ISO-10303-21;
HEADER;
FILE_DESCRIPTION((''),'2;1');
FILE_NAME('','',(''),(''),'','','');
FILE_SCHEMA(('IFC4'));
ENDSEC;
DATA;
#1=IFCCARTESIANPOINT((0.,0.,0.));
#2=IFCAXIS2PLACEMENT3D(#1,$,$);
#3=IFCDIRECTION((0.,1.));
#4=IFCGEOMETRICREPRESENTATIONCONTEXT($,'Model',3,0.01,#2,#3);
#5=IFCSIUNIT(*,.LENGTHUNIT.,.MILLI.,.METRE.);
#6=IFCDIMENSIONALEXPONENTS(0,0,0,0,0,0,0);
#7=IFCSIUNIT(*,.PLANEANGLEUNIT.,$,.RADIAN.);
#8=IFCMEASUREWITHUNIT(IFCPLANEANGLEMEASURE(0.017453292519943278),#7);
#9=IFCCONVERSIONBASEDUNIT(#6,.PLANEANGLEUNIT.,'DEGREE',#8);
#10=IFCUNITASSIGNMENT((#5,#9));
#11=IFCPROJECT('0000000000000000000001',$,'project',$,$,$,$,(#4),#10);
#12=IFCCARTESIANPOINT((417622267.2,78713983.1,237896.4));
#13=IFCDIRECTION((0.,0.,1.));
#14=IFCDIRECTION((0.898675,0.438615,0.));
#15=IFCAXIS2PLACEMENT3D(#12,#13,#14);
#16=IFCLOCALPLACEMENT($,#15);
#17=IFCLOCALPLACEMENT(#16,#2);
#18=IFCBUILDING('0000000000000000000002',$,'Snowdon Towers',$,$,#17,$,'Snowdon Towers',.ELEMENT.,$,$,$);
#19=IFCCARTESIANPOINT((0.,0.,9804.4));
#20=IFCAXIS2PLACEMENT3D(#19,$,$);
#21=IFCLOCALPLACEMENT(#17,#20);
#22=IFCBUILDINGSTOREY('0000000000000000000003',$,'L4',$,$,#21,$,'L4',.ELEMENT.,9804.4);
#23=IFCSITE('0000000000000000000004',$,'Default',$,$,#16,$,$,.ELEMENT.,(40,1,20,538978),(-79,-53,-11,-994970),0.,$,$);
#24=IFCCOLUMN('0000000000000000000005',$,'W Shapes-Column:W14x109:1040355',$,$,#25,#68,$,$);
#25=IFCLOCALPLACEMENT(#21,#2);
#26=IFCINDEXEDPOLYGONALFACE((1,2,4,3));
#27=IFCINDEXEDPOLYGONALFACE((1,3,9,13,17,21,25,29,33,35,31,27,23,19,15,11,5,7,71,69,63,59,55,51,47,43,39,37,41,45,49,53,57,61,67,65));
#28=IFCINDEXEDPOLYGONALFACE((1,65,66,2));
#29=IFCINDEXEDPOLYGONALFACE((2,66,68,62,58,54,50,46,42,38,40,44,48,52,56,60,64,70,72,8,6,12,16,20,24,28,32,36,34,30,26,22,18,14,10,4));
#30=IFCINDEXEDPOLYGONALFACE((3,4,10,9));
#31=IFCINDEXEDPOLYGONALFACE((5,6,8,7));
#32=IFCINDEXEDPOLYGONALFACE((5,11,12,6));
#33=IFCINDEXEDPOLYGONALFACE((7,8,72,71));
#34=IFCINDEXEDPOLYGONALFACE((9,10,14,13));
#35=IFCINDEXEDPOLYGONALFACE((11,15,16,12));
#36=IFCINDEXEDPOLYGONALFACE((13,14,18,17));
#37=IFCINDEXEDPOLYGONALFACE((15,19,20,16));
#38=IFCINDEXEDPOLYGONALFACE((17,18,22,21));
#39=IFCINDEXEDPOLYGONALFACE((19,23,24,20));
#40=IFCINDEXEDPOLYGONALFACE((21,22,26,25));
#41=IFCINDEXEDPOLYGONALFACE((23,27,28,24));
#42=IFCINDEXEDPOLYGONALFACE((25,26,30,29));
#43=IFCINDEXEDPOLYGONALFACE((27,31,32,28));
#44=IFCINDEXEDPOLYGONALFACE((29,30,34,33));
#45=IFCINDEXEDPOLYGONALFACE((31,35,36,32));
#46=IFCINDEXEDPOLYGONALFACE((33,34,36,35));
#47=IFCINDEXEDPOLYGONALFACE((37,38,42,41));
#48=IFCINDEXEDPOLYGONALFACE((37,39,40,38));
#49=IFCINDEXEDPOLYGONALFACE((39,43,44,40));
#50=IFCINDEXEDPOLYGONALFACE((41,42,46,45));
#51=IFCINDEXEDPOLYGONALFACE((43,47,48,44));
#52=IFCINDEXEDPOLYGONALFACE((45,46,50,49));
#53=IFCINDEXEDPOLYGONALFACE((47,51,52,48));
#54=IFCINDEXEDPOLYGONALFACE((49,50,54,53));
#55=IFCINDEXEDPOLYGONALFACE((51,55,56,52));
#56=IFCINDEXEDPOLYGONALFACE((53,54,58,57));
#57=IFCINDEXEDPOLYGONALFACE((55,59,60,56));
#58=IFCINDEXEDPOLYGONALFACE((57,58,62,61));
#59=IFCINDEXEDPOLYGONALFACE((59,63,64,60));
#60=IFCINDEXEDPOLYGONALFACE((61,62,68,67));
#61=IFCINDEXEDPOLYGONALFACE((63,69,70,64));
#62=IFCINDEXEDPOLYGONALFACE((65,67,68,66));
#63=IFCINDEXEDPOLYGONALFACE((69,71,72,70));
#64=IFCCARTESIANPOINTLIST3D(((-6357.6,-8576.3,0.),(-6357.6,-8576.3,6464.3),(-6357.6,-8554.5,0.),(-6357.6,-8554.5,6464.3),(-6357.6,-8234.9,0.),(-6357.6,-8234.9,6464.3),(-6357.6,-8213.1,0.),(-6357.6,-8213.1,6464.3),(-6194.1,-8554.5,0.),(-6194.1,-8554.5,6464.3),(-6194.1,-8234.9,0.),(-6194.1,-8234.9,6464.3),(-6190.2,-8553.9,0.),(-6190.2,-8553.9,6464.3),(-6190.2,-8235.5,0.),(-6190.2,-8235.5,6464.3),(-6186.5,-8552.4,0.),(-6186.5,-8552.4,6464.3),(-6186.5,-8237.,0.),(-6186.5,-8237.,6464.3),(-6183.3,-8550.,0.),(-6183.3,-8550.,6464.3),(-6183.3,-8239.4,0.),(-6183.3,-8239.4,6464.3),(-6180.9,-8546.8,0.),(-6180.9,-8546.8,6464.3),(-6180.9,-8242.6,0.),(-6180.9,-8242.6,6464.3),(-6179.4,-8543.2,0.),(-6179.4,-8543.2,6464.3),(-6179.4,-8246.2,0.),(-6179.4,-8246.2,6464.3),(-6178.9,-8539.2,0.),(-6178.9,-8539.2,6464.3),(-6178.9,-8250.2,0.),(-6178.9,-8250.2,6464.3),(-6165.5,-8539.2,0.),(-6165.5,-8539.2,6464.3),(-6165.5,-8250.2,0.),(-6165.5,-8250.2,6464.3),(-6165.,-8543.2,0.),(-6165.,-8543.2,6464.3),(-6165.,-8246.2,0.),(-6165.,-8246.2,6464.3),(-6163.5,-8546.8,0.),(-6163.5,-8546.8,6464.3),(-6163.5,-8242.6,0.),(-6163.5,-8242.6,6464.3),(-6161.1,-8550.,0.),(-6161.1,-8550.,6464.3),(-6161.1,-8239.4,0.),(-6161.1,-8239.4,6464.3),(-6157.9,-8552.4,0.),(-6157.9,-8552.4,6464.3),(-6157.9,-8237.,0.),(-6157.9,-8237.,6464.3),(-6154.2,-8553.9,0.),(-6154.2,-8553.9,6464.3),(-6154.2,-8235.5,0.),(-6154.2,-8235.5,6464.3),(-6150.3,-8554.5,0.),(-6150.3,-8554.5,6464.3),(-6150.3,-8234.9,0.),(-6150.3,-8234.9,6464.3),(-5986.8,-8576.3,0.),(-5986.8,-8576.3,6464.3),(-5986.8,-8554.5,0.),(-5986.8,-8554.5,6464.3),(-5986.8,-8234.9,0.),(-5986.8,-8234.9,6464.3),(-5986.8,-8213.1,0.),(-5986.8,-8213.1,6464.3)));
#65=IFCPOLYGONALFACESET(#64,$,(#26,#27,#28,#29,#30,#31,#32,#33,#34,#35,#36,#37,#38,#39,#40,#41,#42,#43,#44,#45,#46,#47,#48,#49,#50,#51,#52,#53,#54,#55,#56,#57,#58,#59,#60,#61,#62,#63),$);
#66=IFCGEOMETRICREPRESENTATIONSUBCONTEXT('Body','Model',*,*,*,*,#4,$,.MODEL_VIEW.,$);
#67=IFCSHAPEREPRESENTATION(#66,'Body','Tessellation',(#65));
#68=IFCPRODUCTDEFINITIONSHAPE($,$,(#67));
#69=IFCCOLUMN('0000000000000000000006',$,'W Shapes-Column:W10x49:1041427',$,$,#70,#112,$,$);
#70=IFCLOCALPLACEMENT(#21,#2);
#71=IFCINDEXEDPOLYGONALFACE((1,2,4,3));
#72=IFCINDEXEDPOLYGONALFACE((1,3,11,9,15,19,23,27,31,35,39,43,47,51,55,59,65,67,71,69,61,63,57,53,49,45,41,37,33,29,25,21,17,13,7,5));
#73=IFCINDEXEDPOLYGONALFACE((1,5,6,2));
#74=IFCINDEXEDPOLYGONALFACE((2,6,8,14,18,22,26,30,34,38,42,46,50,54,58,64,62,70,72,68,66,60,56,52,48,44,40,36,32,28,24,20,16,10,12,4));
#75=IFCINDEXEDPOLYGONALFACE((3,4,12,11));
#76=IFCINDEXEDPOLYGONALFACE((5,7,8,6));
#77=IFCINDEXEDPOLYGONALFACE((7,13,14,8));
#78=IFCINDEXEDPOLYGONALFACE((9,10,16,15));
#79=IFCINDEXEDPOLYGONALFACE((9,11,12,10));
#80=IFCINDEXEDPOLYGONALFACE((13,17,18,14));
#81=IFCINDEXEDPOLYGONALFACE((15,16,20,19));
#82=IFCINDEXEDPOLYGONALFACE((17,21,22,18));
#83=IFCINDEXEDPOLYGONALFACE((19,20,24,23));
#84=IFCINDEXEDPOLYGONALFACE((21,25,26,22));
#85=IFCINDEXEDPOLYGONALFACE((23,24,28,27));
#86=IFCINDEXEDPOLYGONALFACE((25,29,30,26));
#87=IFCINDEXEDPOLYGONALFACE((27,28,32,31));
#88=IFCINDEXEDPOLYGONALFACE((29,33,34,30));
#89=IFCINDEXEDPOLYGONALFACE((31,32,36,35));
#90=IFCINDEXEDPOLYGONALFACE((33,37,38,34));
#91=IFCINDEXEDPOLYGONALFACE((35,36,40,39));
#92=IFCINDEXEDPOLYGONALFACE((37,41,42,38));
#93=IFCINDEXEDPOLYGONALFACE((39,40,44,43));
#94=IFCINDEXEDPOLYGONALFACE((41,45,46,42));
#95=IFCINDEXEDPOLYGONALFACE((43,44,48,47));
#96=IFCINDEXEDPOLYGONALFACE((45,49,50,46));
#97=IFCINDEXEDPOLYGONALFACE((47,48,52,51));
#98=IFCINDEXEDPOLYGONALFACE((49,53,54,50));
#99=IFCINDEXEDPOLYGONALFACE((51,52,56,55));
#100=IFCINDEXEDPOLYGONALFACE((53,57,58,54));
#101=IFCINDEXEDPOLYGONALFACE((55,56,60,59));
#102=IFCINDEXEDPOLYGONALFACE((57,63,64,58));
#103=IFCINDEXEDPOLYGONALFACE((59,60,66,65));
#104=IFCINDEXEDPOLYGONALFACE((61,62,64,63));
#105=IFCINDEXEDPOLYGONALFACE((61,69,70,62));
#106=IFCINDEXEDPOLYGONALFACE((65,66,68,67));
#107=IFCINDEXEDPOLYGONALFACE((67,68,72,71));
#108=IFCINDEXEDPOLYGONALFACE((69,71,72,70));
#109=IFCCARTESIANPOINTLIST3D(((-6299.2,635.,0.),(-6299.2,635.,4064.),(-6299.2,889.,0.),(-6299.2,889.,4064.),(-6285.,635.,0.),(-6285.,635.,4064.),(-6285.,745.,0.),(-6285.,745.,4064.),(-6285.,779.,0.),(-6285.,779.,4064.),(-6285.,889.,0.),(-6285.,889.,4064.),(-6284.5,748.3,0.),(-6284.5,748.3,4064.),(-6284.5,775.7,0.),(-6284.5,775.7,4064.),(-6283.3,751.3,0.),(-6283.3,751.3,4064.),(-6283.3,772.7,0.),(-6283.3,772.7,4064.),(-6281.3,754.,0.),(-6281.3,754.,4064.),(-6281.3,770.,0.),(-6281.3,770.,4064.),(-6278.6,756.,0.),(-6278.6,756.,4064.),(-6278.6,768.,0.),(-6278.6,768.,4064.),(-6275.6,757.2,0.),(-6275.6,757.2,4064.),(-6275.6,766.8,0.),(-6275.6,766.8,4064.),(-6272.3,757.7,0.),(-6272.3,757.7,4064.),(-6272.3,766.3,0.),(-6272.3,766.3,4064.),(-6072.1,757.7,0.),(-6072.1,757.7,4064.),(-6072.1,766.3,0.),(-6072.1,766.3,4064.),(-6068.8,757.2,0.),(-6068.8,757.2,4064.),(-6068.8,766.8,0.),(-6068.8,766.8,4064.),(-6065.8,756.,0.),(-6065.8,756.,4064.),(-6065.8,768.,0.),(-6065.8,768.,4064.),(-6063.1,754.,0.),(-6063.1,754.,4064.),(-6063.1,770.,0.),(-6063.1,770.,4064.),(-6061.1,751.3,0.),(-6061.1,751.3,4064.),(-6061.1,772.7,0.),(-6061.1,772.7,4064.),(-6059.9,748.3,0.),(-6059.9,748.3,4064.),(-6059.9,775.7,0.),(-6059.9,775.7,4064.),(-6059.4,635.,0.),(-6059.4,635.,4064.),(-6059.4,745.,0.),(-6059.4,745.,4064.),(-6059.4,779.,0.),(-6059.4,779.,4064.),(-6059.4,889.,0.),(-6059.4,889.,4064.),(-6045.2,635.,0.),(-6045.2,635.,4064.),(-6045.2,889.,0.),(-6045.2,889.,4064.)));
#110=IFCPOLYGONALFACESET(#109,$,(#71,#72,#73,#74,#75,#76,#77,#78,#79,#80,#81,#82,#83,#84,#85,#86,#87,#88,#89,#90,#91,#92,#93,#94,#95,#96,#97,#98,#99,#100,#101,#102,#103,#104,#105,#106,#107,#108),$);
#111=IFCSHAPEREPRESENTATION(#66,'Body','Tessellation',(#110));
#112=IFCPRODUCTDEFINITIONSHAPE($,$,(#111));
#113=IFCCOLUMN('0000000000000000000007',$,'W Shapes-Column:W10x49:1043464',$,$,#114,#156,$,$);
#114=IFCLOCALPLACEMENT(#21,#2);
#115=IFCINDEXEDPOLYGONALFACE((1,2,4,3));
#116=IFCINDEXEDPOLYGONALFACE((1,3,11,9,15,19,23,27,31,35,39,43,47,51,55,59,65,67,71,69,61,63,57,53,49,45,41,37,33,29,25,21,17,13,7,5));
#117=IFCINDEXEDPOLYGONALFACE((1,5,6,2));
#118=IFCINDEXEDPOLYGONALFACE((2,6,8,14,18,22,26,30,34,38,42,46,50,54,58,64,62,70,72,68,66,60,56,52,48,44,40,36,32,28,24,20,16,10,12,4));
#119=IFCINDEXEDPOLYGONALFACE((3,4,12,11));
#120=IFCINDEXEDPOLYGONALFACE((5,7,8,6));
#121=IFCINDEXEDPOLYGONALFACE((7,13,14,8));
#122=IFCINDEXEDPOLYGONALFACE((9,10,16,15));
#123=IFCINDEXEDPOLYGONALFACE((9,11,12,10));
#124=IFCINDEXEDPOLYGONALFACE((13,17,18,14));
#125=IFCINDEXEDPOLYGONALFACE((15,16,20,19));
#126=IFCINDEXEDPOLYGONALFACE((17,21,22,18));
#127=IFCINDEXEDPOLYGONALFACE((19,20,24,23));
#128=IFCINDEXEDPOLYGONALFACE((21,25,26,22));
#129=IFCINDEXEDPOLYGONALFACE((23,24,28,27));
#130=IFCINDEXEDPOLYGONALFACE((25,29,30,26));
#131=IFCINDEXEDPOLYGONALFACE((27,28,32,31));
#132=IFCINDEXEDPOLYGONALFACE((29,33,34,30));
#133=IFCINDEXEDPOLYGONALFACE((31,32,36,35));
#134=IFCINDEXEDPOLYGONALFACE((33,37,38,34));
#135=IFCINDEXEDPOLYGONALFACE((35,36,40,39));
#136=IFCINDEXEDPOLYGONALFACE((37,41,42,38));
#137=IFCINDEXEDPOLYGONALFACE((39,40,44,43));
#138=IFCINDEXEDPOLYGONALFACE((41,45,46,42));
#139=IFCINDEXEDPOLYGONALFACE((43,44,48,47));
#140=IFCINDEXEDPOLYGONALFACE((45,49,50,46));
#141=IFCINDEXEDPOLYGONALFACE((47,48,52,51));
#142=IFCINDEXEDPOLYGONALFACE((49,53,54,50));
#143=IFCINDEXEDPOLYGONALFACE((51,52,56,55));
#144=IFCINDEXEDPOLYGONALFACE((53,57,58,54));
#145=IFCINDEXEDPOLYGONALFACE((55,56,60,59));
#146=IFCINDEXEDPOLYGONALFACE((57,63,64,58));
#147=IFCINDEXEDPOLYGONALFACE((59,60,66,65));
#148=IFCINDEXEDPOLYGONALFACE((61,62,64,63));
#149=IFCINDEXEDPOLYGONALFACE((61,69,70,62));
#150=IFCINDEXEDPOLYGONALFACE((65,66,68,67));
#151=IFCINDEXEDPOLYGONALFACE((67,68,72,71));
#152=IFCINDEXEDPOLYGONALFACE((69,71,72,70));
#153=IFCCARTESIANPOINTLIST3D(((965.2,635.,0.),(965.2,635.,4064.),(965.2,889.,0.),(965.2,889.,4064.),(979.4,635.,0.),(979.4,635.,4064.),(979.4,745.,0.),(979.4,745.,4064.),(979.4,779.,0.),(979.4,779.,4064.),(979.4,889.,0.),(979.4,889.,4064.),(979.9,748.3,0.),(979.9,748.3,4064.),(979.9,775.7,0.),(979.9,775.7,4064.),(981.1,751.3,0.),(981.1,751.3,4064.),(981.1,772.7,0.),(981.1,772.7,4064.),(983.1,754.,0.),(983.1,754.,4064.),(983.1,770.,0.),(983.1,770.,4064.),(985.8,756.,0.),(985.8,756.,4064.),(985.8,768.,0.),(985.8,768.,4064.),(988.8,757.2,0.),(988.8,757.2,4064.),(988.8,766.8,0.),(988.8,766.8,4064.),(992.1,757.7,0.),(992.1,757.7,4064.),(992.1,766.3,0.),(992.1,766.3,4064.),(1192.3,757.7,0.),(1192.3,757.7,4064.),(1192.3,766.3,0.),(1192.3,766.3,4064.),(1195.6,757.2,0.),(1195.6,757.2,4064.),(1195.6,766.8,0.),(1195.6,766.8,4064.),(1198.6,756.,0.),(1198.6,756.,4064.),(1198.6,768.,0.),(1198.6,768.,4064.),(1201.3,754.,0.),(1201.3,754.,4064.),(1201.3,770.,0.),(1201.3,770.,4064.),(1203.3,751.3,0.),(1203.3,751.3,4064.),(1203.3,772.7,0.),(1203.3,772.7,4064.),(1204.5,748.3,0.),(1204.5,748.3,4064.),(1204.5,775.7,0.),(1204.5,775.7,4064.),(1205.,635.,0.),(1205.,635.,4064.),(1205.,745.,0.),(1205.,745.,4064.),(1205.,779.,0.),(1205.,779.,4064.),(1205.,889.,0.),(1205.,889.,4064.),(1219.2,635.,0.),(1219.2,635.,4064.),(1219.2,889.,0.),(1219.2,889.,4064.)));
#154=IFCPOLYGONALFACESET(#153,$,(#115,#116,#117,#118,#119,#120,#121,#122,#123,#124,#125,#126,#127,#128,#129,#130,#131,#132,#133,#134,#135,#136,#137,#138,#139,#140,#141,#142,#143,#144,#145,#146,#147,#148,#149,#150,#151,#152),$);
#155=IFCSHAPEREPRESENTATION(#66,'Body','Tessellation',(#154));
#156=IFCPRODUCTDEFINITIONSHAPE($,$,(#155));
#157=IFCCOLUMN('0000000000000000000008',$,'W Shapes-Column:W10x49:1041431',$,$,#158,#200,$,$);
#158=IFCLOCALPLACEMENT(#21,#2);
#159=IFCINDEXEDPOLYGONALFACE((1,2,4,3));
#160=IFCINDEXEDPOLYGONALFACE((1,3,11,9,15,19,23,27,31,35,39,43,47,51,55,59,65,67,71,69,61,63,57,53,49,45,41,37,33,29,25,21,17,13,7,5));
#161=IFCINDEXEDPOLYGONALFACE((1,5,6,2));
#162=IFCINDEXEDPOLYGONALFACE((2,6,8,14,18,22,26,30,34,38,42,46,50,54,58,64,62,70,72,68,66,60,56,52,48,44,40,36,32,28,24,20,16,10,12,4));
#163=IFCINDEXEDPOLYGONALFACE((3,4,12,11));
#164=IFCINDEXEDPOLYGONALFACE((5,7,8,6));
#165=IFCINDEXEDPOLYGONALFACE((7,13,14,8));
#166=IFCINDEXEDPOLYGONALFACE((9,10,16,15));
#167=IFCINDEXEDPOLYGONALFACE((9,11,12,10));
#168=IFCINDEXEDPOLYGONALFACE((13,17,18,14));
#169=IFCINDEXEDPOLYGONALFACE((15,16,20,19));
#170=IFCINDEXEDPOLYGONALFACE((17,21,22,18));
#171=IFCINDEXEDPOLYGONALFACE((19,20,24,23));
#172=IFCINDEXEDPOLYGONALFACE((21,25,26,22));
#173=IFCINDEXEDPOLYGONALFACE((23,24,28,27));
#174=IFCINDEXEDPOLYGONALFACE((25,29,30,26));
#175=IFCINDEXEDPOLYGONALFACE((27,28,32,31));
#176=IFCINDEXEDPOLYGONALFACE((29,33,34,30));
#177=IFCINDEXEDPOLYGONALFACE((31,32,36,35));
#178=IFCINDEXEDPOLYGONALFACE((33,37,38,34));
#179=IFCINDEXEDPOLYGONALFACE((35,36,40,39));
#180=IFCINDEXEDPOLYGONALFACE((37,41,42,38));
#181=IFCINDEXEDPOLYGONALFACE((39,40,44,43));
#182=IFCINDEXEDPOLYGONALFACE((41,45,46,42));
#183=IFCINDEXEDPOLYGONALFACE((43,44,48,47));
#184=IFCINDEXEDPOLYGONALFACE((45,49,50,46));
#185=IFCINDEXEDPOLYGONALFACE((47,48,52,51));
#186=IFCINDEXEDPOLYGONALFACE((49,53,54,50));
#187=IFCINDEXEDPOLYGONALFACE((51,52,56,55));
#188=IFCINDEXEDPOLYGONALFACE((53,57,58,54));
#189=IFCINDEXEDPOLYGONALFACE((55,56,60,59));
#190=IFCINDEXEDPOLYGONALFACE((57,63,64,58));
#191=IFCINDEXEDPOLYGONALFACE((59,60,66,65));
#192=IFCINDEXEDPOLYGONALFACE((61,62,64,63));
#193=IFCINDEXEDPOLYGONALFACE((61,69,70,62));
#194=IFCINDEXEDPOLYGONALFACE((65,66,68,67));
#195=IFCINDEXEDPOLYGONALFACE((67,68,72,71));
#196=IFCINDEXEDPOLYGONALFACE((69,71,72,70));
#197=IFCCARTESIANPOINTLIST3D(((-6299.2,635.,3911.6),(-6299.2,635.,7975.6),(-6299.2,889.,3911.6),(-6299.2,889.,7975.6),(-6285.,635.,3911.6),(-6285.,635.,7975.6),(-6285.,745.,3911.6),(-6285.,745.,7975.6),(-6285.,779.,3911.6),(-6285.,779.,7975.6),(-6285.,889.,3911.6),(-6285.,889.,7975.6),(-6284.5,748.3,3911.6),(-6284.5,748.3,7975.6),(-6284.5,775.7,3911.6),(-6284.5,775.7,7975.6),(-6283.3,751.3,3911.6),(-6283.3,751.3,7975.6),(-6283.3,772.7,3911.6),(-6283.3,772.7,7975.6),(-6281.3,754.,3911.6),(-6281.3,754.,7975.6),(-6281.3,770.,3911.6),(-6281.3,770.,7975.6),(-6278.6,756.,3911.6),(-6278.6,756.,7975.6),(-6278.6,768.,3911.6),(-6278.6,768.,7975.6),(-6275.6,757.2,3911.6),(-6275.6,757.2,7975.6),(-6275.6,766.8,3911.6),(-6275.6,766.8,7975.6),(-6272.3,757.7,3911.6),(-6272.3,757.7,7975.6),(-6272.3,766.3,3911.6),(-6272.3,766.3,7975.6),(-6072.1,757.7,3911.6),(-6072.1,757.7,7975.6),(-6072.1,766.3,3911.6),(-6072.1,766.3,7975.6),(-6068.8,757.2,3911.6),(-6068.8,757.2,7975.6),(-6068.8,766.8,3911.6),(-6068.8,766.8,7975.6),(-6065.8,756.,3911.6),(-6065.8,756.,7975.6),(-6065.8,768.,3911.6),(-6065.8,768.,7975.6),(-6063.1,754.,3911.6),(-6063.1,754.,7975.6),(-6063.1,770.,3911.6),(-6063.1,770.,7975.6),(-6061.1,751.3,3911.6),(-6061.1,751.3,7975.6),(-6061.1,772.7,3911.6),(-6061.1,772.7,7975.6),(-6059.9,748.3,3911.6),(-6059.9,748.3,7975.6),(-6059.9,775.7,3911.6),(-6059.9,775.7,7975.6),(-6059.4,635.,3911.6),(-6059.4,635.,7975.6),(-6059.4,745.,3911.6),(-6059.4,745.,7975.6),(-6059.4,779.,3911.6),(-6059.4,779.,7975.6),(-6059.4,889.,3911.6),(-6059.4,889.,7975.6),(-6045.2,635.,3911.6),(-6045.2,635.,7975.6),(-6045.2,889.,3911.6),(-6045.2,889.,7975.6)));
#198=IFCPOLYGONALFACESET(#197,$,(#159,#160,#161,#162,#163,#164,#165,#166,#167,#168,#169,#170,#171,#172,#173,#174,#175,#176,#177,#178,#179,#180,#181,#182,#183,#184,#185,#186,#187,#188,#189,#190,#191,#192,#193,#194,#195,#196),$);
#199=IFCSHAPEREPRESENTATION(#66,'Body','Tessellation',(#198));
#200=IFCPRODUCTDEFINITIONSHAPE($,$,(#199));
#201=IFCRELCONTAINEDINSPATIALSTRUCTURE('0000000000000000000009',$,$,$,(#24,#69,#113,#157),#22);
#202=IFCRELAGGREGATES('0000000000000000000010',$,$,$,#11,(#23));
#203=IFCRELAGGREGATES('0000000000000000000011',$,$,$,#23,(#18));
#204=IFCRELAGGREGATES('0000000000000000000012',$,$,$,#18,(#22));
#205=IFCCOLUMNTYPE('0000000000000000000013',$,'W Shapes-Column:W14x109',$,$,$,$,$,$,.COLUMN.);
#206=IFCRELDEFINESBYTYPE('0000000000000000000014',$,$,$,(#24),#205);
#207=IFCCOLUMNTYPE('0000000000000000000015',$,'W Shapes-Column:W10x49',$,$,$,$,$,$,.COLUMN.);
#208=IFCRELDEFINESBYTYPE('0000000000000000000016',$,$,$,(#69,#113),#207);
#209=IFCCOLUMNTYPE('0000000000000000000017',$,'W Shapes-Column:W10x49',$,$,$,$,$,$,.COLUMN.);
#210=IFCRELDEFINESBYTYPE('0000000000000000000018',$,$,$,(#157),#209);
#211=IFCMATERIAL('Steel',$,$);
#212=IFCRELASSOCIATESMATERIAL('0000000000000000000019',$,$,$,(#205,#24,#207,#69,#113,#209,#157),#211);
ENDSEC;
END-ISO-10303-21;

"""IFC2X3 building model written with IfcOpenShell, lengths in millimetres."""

from ifc_helpers import new_model, entity, si_unit, converted_unit, direction, frame, frame_2d, origin, place, context, subcontext, project, spatial, i_section, extrude, source, transform, mapped, material, type_object, type_shapes, element, save


model = new_model("IFC2X3")

# Units and contexts
model_context = context("Model", 3, precision=0.01, world=origin(), true_north=direction((0.0, 1.0)))
body_context = subcontext(model_context, "Body", "Model", "MODEL_VIEW")
ifc_project = project(units=[si_unit("LENGTHUNIT", "METRE", prefix="MILLI"), converted_unit("PLANEANGLEUNIT", "DEGREE", entity("IfcPlaneAngleMeasure", 0.017453292519943278), si_unit("PLANEANGLEUNIT", "RADIAN"), dimensions=[0, 0, 0, 0, 0, 0, 0])], contexts=[model_context])

# Site, building, storey
site_placement = place(None, frame((417622267.2, 78713983.1, 237896.4), z_axis=(0.0, 0.0, 1.0), x_axis=(0.898675, 0.438615, 0.0)))
site = spatial("IfcSite", under=ifc_project, at=site_placement, Name="Default", CompositionType="ELEMENT", RefLatitude=(40, 1, 20, 538978), RefLongitude=(-79, -53, -11, -994970), RefElevation=0.0)
building_placement = place(site_placement, origin())
building = spatial("IfcBuilding", under=site, at=building_placement, Name="Snowdon Towers", LongName="Snowdon Towers", CompositionType="ELEMENT")
storey_placement = place(building_placement, frame((0.0, 0.0, 9804.4)))
storey = spatial("IfcBuildingStorey", under=building, at=storey_placement, Name="L4", LongName="L4", CompositionType="ELEMENT", Elevation=9804.4)

# Columns
ifc_material_1 = material(Name="Steel")
column_type_1 = type_object("IfcColumnType", Name="W Shapes-Column:W14x109", PredefinedType="COLUMN", material=ifc_material_1)
shared_shape_1 = source(origin(), body_context, "Body", "SweptSolid", [
    extrude(i_section(OverallWidth=370.8, OverallDepth=363.2, WebThickness=13.3, FlangeThickness=21.8, FilletRadius=15.2, at=frame_2d((0.0, 0.0), x_axis=(1.0, 0.0))), frame((0.0, 0.0, 9804.4), z_axis=(0.0, 0.0, 1.0), x_axis=(-1.0, 0.0, 0.0)), (0.0, 0.0, 1.0), 6464.3),
])
type_shapes(column_type_1, [shared_shape_1])
column_1_placement = place(storey_placement, frame((-6172.2, -8394.7, -9804.4), z_axis=(0.0, 0.0, 1.0), x_axis=(-1.0, 0.0, 0.0)))
element("IfcColumn", 1, at=column_1_placement, inside=storey, type_object=column_type_1, material=ifc_material_1, Name="W Shapes-Column:W14x109:1040355", context=body_context, shape_type="MappedRepresentation", body=[
    mapped(shared_shape_1, transform((0.0, 0.0, 0.0), scale=1.0)),
])
column_type_2 = type_object("IfcColumnType", Name="W Shapes-Column:W10x49", PredefinedType="COLUMN", material=ifc_material_1)
shared_shape_2 = source(origin(), body_context, "Body", "SweptSolid", [
    extrude(i_section(OverallWidth=254.0, OverallDepth=254.0, WebThickness=8.6, FlangeThickness=14.2, FilletRadius=12.7, at=frame_2d((0.0, 0.0), x_axis=(1.0, 0.0))), frame((0.0, 0.0, 9804.4), z_axis=(0.0, 0.0, 1.0), x_axis=(-1.0, 0.0, 0.0)), (0.0, 0.0, 1.0), 4064.0),
])
type_shapes(column_type_2, [shared_shape_2])
for number, where, z_axis, x_axis, name in (
    (2, (-6172.2, 762.0, -9804.4), (0.0, 0.0, 1.0), (0.0, 1.0, 0.0), "W Shapes-Column:W10x49:1041427"),
    (3, (1092.2, 762.0, -9804.4), (0.0, 0.0, 1.0), (0.0, 1.0, 0.0), "W Shapes-Column:W10x49:1043464"),
):
    element("IfcColumn", number, at=place(storey_placement, frame(where, z_axis=z_axis, x_axis=x_axis)), inside=storey, type_object=column_type_2, material=ifc_material_1, Name=name, context=body_context, shape_type="MappedRepresentation", body=[
        mapped(shared_shape_2, transform((0.0, 0.0, 0.0), scale=1.0)),
    ])
column_type_3 = type_object("IfcColumnType", Name="W Shapes-Column:W10x49", PredefinedType="COLUMN", material=ifc_material_1)
shared_shape_3 = source(origin(), body_context, "Body", "SweptSolid", [
    extrude(i_section(OverallWidth=254.0, OverallDepth=254.0, WebThickness=8.6, FlangeThickness=14.2, FilletRadius=12.7, at=frame_2d((0.0, 0.0), x_axis=(1.0, 0.0))), frame((0.0, 0.0, 13716.0), z_axis=(0.0, 0.0, 1.0), x_axis=(-1.0, 0.0, 0.0)), (0.0, 0.0, 1.0), 4064.0),
])
type_shapes(column_type_3, [shared_shape_3])
column_2_placement = place(storey_placement, frame((-6172.2, 762.0, -9804.4), z_axis=(0.0, 0.0, 1.0), x_axis=(0.0, 1.0, 0.0)))
element("IfcColumn", 4, at=column_2_placement, inside=storey, type_object=column_type_3, material=ifc_material_1, Name="W Shapes-Column:W10x49:1041431", context=body_context, shape_type="MappedRepresentation", body=[
    mapped(shared_shape_3, transform((0.0, 0.0, 0.0), scale=1.0)),
])

save(model, "model.ifc")
